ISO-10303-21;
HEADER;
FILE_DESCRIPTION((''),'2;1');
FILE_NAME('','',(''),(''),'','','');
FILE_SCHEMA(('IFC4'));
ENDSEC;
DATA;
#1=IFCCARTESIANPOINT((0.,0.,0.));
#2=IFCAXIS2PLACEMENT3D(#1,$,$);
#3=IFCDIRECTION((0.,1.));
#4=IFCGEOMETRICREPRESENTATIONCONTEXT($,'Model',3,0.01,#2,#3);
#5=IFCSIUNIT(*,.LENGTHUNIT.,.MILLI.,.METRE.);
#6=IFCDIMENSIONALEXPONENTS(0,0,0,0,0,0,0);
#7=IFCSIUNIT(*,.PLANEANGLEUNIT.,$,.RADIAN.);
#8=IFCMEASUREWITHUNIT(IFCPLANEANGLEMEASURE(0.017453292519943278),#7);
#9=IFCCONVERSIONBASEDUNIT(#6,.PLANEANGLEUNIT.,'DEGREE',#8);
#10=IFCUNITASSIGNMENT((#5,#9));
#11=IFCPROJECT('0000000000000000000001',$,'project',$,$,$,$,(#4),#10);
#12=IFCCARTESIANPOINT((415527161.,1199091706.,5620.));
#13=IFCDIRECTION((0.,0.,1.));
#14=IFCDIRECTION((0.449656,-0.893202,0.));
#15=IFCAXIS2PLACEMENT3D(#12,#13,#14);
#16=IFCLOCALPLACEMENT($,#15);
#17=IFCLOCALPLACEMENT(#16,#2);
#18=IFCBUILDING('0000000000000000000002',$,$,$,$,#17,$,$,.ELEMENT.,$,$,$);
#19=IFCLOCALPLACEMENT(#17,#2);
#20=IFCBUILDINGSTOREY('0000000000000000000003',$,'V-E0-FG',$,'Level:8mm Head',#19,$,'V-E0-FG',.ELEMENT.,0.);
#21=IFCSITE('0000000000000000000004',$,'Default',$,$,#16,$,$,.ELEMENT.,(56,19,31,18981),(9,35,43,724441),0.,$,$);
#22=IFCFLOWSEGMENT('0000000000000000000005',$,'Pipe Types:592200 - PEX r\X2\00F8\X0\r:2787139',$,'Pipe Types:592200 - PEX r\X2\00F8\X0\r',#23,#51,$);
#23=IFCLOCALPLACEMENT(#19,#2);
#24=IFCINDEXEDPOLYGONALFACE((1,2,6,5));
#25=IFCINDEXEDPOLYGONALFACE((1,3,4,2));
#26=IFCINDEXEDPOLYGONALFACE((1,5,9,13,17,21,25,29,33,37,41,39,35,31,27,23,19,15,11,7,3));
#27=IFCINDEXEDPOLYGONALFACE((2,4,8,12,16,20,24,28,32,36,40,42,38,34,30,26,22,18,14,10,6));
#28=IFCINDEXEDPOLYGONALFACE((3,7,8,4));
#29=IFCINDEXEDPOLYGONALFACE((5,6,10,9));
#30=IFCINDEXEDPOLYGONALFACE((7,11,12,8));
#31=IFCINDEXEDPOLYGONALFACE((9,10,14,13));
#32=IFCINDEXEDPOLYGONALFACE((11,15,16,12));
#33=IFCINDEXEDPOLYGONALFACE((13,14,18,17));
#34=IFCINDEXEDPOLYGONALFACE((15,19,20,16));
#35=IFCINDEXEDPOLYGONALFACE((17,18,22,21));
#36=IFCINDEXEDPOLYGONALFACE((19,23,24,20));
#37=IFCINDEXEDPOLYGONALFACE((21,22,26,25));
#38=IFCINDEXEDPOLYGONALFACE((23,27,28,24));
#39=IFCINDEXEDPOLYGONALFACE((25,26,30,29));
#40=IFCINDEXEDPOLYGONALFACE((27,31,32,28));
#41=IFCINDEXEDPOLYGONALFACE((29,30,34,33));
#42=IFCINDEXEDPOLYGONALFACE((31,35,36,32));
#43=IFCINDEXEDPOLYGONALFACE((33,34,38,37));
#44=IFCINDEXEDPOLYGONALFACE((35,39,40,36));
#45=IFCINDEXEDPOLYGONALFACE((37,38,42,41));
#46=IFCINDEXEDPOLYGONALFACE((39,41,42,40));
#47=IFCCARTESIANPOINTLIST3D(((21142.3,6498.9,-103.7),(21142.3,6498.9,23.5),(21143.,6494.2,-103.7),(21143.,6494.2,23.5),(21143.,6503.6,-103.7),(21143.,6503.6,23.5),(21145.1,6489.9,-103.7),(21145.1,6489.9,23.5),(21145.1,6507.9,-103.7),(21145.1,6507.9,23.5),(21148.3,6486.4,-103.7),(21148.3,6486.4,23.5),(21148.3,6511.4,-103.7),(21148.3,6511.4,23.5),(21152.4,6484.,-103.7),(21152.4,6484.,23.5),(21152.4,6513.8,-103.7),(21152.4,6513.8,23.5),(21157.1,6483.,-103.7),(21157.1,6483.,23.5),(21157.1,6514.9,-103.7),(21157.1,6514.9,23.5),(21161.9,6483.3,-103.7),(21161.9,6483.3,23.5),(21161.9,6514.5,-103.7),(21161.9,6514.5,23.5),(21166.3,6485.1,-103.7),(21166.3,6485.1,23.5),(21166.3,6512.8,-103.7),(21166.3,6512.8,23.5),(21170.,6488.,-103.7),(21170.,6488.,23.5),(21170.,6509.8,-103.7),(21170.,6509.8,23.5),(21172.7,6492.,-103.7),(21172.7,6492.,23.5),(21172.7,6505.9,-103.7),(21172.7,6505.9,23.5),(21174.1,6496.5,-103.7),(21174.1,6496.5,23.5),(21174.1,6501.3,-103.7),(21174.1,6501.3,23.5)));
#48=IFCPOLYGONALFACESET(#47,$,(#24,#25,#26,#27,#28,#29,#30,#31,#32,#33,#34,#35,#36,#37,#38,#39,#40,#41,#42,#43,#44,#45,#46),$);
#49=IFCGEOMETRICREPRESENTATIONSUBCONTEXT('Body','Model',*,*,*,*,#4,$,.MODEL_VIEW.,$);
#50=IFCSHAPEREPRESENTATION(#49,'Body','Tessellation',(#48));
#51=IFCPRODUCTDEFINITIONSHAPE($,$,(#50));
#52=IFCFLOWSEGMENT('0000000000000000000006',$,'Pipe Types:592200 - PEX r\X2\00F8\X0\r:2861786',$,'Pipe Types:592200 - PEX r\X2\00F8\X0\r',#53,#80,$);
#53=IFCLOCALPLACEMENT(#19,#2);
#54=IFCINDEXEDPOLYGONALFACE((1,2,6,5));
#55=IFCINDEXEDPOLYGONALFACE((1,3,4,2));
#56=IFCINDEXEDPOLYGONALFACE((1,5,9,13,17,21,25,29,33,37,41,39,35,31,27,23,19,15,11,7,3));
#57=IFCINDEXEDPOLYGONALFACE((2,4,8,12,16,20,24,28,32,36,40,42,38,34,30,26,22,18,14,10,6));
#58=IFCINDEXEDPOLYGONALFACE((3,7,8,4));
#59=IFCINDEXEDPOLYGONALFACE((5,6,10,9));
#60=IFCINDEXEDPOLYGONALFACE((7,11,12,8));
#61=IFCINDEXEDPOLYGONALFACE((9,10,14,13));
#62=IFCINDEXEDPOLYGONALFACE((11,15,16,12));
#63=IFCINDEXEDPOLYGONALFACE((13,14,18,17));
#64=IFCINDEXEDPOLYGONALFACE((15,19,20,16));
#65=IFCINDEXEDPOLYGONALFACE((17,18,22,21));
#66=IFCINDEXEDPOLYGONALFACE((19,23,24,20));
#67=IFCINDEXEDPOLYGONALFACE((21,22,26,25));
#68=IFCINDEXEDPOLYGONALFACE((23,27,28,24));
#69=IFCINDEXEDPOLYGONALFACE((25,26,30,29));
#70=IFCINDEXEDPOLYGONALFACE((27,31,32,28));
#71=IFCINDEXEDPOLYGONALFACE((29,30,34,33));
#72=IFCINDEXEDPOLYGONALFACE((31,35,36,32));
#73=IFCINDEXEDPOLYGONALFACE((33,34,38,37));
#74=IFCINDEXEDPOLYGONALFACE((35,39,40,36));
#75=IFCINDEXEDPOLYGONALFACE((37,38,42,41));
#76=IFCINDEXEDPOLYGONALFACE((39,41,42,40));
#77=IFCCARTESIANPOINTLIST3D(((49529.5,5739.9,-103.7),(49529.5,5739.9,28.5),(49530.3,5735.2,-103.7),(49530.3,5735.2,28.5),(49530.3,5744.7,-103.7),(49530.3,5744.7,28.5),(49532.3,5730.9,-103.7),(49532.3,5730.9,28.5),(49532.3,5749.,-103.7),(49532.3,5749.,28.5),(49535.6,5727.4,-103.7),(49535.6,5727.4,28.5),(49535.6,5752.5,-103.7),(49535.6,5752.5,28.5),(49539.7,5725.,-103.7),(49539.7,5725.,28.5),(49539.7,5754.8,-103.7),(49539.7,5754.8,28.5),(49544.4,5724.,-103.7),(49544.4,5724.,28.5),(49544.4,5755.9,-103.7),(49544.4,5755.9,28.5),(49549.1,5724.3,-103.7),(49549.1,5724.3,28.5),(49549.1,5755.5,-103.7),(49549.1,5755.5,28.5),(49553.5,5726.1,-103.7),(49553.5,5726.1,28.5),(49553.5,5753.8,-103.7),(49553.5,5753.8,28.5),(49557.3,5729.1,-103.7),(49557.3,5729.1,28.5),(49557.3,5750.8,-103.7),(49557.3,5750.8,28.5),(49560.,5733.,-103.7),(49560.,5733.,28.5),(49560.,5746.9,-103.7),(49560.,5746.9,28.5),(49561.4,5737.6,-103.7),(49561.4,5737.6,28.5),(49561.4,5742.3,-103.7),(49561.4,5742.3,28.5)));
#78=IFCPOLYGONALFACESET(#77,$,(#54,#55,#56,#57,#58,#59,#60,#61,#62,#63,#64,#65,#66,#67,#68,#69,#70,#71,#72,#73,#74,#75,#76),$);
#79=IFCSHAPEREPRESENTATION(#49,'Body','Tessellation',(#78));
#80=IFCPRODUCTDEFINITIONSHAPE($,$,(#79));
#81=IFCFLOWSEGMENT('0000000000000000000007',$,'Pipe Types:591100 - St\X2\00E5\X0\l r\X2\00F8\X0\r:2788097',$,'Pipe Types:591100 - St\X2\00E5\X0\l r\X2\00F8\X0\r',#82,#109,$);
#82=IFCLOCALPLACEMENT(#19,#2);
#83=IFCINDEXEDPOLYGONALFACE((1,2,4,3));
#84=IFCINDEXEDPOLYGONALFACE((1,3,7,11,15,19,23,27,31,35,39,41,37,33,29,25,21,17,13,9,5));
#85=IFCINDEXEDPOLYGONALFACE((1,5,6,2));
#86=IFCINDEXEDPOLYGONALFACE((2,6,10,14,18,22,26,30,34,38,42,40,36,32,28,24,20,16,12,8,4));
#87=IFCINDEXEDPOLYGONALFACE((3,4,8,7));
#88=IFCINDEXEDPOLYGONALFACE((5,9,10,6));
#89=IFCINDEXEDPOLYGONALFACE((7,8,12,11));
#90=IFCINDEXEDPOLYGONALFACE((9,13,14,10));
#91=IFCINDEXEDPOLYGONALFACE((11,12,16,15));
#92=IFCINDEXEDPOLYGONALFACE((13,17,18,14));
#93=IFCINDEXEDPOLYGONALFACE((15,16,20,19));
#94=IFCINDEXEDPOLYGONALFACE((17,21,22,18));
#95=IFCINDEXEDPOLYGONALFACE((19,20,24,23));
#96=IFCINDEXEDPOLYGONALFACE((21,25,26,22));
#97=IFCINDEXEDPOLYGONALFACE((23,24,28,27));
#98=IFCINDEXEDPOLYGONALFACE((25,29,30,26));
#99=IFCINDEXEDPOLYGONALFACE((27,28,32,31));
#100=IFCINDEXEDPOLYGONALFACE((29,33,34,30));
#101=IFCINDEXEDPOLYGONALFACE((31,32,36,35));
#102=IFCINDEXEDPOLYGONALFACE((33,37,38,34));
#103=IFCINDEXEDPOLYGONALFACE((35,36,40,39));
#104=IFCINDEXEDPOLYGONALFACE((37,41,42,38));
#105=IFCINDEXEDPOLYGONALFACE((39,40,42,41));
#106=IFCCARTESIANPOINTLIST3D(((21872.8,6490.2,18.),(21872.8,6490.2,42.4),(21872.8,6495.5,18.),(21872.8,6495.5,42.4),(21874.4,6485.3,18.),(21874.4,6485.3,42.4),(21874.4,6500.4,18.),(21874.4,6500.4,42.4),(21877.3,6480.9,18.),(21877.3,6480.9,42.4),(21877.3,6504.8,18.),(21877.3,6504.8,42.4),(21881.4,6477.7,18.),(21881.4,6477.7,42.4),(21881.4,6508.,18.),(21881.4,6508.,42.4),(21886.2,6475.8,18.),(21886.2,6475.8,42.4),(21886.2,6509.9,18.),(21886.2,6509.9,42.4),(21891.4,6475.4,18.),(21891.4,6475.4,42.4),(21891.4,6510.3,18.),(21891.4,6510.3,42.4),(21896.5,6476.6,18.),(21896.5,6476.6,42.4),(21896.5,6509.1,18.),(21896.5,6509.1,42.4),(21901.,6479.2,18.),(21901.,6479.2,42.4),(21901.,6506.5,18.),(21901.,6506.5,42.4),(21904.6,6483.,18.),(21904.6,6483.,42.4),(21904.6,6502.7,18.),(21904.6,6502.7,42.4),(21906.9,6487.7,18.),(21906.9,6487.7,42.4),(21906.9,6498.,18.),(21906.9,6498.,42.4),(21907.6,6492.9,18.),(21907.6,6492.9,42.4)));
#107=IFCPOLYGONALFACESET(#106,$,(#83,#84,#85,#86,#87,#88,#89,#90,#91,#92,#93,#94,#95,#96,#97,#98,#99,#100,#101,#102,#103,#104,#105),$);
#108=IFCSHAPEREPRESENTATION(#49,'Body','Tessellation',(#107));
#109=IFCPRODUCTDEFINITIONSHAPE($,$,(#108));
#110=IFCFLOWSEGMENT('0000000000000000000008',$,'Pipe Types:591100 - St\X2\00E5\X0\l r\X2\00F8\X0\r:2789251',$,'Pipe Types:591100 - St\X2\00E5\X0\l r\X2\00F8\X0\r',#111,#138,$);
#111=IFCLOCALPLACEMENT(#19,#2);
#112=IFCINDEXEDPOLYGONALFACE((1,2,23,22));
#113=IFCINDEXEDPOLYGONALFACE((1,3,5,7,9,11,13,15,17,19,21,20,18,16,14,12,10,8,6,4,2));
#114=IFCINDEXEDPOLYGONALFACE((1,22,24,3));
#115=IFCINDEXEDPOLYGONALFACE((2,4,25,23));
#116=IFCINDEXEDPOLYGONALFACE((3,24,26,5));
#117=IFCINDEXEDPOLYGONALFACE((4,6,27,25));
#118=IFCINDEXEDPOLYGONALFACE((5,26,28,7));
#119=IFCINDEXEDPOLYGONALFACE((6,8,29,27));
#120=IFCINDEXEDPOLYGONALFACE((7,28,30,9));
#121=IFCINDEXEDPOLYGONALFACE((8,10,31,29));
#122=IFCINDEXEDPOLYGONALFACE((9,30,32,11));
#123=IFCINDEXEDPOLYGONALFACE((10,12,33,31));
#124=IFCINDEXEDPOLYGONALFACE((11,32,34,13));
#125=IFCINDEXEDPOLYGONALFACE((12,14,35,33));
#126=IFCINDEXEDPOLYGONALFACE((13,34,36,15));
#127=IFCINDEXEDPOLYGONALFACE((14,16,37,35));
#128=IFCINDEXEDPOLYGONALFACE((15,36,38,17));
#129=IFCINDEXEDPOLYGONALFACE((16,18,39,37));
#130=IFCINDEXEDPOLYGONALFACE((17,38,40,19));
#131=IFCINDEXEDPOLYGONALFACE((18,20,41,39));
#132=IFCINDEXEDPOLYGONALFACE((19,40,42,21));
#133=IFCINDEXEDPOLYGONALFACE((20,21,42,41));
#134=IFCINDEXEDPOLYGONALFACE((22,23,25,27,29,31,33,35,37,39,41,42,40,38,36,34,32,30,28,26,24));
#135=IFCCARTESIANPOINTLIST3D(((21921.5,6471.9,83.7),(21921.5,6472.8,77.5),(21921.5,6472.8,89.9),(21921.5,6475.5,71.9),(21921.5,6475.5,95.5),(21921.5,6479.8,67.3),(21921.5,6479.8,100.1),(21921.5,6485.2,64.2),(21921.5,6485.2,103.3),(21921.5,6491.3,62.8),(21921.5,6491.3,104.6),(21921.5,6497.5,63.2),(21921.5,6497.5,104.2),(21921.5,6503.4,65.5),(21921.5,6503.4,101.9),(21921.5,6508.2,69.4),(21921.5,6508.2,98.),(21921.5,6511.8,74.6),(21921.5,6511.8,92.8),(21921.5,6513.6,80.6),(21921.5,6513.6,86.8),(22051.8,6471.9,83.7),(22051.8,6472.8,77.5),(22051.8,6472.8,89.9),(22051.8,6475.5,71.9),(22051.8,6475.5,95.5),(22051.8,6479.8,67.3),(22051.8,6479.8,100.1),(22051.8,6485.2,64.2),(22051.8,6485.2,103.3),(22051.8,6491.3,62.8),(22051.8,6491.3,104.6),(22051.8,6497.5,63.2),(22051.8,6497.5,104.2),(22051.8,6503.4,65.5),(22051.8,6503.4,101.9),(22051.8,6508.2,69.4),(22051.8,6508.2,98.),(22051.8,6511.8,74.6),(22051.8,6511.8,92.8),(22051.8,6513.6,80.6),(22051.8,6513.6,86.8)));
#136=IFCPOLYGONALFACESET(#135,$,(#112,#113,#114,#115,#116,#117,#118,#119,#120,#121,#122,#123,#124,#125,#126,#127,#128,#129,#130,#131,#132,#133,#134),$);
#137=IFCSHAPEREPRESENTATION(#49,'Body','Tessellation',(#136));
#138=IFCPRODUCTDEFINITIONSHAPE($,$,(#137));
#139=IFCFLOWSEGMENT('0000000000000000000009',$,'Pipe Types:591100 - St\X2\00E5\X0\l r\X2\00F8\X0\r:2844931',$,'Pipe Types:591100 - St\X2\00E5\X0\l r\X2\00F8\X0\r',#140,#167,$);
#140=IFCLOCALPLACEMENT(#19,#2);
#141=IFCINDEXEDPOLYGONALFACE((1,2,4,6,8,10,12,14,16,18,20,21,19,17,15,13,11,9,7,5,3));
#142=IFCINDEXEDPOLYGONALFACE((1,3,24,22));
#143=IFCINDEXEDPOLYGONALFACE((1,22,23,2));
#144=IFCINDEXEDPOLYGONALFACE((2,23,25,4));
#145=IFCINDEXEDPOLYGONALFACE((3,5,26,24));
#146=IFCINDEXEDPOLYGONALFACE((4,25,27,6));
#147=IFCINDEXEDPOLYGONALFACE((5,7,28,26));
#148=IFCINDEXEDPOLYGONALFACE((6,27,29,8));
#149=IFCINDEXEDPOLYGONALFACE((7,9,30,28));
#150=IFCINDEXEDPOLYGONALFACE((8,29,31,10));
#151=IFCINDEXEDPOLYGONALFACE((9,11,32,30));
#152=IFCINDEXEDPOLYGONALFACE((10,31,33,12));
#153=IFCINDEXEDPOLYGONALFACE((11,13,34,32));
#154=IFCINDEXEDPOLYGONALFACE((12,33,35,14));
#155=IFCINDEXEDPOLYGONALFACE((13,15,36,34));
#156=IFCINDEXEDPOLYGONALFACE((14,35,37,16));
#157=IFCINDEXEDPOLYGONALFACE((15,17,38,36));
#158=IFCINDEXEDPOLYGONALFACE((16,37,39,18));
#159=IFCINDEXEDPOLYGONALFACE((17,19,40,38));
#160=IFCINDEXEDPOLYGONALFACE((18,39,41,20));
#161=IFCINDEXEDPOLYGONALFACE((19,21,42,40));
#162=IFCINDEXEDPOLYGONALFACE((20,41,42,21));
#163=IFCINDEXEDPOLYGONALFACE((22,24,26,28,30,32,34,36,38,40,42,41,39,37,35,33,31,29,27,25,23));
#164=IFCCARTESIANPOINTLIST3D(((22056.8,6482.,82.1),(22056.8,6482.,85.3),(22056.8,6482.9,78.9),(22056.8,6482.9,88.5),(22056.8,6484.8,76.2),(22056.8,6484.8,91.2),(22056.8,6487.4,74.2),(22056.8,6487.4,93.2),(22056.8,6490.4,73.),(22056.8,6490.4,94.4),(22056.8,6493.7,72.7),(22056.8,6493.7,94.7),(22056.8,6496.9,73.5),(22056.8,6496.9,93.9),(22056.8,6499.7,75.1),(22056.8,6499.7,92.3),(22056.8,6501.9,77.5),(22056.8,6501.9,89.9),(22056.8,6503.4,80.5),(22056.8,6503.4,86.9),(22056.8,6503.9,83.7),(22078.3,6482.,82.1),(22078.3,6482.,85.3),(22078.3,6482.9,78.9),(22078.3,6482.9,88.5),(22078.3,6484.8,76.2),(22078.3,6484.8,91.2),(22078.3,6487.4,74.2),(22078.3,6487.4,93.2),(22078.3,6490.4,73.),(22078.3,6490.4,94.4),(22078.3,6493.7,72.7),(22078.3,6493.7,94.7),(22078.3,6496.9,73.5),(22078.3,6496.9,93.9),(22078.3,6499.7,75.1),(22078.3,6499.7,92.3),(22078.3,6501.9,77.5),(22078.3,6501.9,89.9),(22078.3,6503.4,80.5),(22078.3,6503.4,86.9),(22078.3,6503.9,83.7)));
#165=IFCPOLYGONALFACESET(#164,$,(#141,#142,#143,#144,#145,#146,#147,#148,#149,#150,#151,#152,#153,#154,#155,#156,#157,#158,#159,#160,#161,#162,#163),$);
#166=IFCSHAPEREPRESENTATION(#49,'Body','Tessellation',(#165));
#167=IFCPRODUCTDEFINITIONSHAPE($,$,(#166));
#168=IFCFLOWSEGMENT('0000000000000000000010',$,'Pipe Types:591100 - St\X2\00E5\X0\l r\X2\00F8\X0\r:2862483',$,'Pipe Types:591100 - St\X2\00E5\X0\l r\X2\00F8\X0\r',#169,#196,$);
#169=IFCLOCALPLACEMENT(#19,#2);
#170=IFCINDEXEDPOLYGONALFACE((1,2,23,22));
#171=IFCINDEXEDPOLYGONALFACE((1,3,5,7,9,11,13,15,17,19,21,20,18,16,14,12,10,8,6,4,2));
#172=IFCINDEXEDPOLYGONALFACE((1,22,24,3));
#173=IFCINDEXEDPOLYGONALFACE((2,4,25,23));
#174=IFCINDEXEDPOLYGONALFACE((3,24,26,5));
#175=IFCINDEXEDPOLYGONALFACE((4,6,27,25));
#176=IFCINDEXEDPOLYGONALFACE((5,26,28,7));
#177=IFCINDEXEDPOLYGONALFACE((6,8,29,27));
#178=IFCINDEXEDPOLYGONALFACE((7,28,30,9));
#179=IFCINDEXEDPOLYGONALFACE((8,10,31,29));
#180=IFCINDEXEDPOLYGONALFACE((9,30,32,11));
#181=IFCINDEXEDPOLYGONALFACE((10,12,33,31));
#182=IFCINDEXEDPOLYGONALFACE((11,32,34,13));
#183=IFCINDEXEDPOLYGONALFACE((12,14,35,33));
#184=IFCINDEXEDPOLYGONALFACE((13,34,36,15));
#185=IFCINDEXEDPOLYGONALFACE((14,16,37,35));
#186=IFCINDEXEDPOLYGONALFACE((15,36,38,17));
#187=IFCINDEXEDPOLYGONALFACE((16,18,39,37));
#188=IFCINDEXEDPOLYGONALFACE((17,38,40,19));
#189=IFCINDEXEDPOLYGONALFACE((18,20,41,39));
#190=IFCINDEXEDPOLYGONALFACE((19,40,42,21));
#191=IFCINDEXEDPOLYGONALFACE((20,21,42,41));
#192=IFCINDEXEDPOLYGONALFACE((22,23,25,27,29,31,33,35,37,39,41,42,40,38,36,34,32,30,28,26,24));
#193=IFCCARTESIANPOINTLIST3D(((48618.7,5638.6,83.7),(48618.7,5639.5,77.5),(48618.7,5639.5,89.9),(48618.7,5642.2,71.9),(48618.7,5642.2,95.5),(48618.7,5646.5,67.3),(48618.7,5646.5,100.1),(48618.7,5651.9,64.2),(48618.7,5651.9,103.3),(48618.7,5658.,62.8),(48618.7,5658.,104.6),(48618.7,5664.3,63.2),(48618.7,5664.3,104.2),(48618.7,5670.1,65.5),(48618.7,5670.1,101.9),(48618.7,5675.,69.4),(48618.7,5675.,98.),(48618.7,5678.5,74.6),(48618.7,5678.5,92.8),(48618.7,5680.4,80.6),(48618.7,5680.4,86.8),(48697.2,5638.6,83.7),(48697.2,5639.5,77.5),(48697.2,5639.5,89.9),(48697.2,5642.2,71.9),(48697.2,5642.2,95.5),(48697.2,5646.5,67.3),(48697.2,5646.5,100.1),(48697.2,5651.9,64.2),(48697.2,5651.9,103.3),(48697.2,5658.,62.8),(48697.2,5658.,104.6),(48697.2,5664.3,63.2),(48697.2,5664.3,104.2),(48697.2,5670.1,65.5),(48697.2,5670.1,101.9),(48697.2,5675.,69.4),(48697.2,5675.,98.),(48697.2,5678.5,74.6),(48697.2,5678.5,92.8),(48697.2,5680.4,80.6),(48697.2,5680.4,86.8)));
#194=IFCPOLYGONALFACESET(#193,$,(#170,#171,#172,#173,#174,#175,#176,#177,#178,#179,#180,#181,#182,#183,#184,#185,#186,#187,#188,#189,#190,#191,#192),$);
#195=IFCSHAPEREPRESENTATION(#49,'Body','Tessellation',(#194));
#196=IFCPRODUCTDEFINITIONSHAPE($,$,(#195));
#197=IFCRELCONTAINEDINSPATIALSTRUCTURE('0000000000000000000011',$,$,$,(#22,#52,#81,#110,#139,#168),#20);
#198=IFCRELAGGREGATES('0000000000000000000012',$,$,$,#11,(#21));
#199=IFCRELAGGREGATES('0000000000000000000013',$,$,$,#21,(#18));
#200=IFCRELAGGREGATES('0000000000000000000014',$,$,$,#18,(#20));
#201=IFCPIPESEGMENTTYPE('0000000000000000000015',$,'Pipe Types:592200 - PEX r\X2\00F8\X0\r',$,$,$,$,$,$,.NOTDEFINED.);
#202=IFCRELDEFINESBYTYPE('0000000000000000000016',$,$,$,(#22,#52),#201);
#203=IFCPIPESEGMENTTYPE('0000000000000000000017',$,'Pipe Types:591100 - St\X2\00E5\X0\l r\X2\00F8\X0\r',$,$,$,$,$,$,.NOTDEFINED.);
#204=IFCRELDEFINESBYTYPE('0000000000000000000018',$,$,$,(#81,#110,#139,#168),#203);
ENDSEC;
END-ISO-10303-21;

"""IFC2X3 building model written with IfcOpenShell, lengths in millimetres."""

from ifc_helpers import new_model, entity, si_unit, converted_unit, direction, frame, frame_2d, origin, origin_2d_with_axis, place, context, subcontext, project, spatial, circle, extrude, type_object, element, save


model = new_model("IFC2X3")

# Units and contexts
model_context = context("Model", 3, precision=0.01, world=origin(), true_north=direction((0.0, 1.0)))
body_context = subcontext(model_context, "Body", "Model", "MODEL_VIEW")
ifc_project = project(units=[si_unit("LENGTHUNIT", "METRE", prefix="MILLI"), converted_unit("PLANEANGLEUNIT", "DEGREE", entity("IfcPlaneAngleMeasure", 0.017453292519943278), si_unit("PLANEANGLEUNIT", "RADIAN"), dimensions=[0, 0, 0, 0, 0, 0, 0])], contexts=[model_context])

# Site, building, storey
site_placement = place(None, frame((415527161.0, 1199091706.0, 5620.0), z_axis=(0.0, 0.0, 1.0), x_axis=(0.449656, -0.893202, 0.0)))
site = spatial("IfcSite", under=ifc_project, at=site_placement, Name="Default", CompositionType="ELEMENT", RefLatitude=(56, 19, 31, 18981), RefLongitude=(9, 35, 43, 724441), RefElevation=0.0)
building_placement = place(site_placement, origin())
building = spatial("IfcBuilding", under=site, at=building_placement, CompositionType="ELEMENT")
storey_placement = place(building_placement, origin())
storey = spatial("IfcBuildingStorey", under=building, at=storey_placement, Name="V-E0-FG", ObjectType="Level:8mm Head", LongName="V-E0-FG", CompositionType="ELEMENT", Elevation=0.0)

# Flow segments
pipe_segment_type_1 = type_object("IfcPipeSegmentType", Name="Pipe Types:592200 - PEX rør", PredefinedType="NOTDEFINED")
flow_segment_1_placement = place(storey_placement, origin())
element("IfcFlowSegment", 1, at=flow_segment_1_placement, inside=storey, type_object=pipe_segment_type_1, Name="Pipe Types:592200 - PEX rør:2787139", ObjectType="Pipe Types:592200 - PEX rør", context=body_context, shape_type="SweptSolid", body=[
    extrude(circle(Radius=16.0, at=origin_2d_with_axis()), frame((21158.3, 6498.9, -103.7), z_axis=(0.0, 0.0, 1.0), x_axis=(-1.0, 0.0, 0.0)), (0.0, 0.0, 1.0), 127.2),
])
flow_segment_2_placement = place(storey_placement, origin())
element("IfcFlowSegment", 2, at=flow_segment_2_placement, inside=storey, type_object=pipe_segment_type_1, Name="Pipe Types:592200 - PEX rør:2861786", ObjectType="Pipe Types:592200 - PEX rør", context=body_context, shape_type="SweptSolid", body=[
    extrude(circle(Radius=16.0, at=origin_2d_with_axis()), frame((49545.5, 5739.9, -103.7), z_axis=(0.0, 0.0, 1.0), x_axis=(-1.0, 0.0, 0.0)), (0.0, 0.0, 1.0), 132.2),
])
pipe_segment_type_2 = type_object("IfcPipeSegmentType", Name="Pipe Types:591100 - Stål rør", PredefinedType="NOTDEFINED")
flow_segment_3_placement = place(storey_placement, origin())
element("IfcFlowSegment", 3, at=flow_segment_3_placement, inside=storey, type_object=pipe_segment_type_2, Name="Pipe Types:591100 - Stål rør:2788097", ObjectType="Pipe Types:591100 - Stål rør", context=body_context, shape_type="SweptSolid", body=[
    extrude(circle(Radius=17.5, at=origin_2d_with_axis()), frame((21890.1, 6492.9, 18.0)), (0.0, 0.0, 1.0), 24.4),
])
flow_segment_4_placement = place(storey_placement, origin())
element("IfcFlowSegment", 4, at=flow_segment_4_placement, inside=storey, type_object=pipe_segment_type_2, Name="Pipe Types:591100 - Stål rør:2789251", ObjectType="Pipe Types:591100 - Stål rør", context=body_context, shape_type="SweptSolid", body=[
    extrude(circle(Radius=21.0, at=frame_2d((0.0, 0.0), x_axis=(1.0, 0.0))), frame((21921.5, 6492.9, 83.7), z_axis=(1.0, 0.0, 0.0), x_axis=(0.0, -1.0, 0.0)), (0.0, 0.0, 1.0), 130.3),
])
flow_segment_5_placement = place(storey_placement, origin())
element("IfcFlowSegment", 5, at=flow_segment_5_placement, inside=storey, type_object=pipe_segment_type_2, Name="Pipe Types:591100 - Stål rør:2844931", ObjectType="Pipe Types:591100 - Stål rør", context=body_context, shape_type="SweptSolid", body=[
    extrude(circle(Radius=11.0, at=origin_2d_with_axis()), frame((22056.8, 6492.9, 83.7), z_axis=(1.0, -0.000002, 0.0), x_axis=(0.000002, 1.0, 0.0)), (0.0, 0.0, 1.0), 21.5),
])
flow_segment_6_placement = place(storey_placement, origin())
element("IfcFlowSegment", 6, at=flow_segment_6_placement, inside=storey, type_object=pipe_segment_type_2, Name="Pipe Types:591100 - Stål rør:2862483", ObjectType="Pipe Types:591100 - Stål rør", context=body_context, shape_type="SweptSolid", body=[
    extrude(circle(Radius=21.0, at=frame_2d((0.0, 0.0), x_axis=(1.0, 0.0))), frame((48618.7, 5659.6, 83.7), z_axis=(1.0, 0.0, 0.0), x_axis=(0.0, -1.0, 0.0)), (0.0, 0.0, 1.0), 78.5),
])

save(model, "model.ifc")
